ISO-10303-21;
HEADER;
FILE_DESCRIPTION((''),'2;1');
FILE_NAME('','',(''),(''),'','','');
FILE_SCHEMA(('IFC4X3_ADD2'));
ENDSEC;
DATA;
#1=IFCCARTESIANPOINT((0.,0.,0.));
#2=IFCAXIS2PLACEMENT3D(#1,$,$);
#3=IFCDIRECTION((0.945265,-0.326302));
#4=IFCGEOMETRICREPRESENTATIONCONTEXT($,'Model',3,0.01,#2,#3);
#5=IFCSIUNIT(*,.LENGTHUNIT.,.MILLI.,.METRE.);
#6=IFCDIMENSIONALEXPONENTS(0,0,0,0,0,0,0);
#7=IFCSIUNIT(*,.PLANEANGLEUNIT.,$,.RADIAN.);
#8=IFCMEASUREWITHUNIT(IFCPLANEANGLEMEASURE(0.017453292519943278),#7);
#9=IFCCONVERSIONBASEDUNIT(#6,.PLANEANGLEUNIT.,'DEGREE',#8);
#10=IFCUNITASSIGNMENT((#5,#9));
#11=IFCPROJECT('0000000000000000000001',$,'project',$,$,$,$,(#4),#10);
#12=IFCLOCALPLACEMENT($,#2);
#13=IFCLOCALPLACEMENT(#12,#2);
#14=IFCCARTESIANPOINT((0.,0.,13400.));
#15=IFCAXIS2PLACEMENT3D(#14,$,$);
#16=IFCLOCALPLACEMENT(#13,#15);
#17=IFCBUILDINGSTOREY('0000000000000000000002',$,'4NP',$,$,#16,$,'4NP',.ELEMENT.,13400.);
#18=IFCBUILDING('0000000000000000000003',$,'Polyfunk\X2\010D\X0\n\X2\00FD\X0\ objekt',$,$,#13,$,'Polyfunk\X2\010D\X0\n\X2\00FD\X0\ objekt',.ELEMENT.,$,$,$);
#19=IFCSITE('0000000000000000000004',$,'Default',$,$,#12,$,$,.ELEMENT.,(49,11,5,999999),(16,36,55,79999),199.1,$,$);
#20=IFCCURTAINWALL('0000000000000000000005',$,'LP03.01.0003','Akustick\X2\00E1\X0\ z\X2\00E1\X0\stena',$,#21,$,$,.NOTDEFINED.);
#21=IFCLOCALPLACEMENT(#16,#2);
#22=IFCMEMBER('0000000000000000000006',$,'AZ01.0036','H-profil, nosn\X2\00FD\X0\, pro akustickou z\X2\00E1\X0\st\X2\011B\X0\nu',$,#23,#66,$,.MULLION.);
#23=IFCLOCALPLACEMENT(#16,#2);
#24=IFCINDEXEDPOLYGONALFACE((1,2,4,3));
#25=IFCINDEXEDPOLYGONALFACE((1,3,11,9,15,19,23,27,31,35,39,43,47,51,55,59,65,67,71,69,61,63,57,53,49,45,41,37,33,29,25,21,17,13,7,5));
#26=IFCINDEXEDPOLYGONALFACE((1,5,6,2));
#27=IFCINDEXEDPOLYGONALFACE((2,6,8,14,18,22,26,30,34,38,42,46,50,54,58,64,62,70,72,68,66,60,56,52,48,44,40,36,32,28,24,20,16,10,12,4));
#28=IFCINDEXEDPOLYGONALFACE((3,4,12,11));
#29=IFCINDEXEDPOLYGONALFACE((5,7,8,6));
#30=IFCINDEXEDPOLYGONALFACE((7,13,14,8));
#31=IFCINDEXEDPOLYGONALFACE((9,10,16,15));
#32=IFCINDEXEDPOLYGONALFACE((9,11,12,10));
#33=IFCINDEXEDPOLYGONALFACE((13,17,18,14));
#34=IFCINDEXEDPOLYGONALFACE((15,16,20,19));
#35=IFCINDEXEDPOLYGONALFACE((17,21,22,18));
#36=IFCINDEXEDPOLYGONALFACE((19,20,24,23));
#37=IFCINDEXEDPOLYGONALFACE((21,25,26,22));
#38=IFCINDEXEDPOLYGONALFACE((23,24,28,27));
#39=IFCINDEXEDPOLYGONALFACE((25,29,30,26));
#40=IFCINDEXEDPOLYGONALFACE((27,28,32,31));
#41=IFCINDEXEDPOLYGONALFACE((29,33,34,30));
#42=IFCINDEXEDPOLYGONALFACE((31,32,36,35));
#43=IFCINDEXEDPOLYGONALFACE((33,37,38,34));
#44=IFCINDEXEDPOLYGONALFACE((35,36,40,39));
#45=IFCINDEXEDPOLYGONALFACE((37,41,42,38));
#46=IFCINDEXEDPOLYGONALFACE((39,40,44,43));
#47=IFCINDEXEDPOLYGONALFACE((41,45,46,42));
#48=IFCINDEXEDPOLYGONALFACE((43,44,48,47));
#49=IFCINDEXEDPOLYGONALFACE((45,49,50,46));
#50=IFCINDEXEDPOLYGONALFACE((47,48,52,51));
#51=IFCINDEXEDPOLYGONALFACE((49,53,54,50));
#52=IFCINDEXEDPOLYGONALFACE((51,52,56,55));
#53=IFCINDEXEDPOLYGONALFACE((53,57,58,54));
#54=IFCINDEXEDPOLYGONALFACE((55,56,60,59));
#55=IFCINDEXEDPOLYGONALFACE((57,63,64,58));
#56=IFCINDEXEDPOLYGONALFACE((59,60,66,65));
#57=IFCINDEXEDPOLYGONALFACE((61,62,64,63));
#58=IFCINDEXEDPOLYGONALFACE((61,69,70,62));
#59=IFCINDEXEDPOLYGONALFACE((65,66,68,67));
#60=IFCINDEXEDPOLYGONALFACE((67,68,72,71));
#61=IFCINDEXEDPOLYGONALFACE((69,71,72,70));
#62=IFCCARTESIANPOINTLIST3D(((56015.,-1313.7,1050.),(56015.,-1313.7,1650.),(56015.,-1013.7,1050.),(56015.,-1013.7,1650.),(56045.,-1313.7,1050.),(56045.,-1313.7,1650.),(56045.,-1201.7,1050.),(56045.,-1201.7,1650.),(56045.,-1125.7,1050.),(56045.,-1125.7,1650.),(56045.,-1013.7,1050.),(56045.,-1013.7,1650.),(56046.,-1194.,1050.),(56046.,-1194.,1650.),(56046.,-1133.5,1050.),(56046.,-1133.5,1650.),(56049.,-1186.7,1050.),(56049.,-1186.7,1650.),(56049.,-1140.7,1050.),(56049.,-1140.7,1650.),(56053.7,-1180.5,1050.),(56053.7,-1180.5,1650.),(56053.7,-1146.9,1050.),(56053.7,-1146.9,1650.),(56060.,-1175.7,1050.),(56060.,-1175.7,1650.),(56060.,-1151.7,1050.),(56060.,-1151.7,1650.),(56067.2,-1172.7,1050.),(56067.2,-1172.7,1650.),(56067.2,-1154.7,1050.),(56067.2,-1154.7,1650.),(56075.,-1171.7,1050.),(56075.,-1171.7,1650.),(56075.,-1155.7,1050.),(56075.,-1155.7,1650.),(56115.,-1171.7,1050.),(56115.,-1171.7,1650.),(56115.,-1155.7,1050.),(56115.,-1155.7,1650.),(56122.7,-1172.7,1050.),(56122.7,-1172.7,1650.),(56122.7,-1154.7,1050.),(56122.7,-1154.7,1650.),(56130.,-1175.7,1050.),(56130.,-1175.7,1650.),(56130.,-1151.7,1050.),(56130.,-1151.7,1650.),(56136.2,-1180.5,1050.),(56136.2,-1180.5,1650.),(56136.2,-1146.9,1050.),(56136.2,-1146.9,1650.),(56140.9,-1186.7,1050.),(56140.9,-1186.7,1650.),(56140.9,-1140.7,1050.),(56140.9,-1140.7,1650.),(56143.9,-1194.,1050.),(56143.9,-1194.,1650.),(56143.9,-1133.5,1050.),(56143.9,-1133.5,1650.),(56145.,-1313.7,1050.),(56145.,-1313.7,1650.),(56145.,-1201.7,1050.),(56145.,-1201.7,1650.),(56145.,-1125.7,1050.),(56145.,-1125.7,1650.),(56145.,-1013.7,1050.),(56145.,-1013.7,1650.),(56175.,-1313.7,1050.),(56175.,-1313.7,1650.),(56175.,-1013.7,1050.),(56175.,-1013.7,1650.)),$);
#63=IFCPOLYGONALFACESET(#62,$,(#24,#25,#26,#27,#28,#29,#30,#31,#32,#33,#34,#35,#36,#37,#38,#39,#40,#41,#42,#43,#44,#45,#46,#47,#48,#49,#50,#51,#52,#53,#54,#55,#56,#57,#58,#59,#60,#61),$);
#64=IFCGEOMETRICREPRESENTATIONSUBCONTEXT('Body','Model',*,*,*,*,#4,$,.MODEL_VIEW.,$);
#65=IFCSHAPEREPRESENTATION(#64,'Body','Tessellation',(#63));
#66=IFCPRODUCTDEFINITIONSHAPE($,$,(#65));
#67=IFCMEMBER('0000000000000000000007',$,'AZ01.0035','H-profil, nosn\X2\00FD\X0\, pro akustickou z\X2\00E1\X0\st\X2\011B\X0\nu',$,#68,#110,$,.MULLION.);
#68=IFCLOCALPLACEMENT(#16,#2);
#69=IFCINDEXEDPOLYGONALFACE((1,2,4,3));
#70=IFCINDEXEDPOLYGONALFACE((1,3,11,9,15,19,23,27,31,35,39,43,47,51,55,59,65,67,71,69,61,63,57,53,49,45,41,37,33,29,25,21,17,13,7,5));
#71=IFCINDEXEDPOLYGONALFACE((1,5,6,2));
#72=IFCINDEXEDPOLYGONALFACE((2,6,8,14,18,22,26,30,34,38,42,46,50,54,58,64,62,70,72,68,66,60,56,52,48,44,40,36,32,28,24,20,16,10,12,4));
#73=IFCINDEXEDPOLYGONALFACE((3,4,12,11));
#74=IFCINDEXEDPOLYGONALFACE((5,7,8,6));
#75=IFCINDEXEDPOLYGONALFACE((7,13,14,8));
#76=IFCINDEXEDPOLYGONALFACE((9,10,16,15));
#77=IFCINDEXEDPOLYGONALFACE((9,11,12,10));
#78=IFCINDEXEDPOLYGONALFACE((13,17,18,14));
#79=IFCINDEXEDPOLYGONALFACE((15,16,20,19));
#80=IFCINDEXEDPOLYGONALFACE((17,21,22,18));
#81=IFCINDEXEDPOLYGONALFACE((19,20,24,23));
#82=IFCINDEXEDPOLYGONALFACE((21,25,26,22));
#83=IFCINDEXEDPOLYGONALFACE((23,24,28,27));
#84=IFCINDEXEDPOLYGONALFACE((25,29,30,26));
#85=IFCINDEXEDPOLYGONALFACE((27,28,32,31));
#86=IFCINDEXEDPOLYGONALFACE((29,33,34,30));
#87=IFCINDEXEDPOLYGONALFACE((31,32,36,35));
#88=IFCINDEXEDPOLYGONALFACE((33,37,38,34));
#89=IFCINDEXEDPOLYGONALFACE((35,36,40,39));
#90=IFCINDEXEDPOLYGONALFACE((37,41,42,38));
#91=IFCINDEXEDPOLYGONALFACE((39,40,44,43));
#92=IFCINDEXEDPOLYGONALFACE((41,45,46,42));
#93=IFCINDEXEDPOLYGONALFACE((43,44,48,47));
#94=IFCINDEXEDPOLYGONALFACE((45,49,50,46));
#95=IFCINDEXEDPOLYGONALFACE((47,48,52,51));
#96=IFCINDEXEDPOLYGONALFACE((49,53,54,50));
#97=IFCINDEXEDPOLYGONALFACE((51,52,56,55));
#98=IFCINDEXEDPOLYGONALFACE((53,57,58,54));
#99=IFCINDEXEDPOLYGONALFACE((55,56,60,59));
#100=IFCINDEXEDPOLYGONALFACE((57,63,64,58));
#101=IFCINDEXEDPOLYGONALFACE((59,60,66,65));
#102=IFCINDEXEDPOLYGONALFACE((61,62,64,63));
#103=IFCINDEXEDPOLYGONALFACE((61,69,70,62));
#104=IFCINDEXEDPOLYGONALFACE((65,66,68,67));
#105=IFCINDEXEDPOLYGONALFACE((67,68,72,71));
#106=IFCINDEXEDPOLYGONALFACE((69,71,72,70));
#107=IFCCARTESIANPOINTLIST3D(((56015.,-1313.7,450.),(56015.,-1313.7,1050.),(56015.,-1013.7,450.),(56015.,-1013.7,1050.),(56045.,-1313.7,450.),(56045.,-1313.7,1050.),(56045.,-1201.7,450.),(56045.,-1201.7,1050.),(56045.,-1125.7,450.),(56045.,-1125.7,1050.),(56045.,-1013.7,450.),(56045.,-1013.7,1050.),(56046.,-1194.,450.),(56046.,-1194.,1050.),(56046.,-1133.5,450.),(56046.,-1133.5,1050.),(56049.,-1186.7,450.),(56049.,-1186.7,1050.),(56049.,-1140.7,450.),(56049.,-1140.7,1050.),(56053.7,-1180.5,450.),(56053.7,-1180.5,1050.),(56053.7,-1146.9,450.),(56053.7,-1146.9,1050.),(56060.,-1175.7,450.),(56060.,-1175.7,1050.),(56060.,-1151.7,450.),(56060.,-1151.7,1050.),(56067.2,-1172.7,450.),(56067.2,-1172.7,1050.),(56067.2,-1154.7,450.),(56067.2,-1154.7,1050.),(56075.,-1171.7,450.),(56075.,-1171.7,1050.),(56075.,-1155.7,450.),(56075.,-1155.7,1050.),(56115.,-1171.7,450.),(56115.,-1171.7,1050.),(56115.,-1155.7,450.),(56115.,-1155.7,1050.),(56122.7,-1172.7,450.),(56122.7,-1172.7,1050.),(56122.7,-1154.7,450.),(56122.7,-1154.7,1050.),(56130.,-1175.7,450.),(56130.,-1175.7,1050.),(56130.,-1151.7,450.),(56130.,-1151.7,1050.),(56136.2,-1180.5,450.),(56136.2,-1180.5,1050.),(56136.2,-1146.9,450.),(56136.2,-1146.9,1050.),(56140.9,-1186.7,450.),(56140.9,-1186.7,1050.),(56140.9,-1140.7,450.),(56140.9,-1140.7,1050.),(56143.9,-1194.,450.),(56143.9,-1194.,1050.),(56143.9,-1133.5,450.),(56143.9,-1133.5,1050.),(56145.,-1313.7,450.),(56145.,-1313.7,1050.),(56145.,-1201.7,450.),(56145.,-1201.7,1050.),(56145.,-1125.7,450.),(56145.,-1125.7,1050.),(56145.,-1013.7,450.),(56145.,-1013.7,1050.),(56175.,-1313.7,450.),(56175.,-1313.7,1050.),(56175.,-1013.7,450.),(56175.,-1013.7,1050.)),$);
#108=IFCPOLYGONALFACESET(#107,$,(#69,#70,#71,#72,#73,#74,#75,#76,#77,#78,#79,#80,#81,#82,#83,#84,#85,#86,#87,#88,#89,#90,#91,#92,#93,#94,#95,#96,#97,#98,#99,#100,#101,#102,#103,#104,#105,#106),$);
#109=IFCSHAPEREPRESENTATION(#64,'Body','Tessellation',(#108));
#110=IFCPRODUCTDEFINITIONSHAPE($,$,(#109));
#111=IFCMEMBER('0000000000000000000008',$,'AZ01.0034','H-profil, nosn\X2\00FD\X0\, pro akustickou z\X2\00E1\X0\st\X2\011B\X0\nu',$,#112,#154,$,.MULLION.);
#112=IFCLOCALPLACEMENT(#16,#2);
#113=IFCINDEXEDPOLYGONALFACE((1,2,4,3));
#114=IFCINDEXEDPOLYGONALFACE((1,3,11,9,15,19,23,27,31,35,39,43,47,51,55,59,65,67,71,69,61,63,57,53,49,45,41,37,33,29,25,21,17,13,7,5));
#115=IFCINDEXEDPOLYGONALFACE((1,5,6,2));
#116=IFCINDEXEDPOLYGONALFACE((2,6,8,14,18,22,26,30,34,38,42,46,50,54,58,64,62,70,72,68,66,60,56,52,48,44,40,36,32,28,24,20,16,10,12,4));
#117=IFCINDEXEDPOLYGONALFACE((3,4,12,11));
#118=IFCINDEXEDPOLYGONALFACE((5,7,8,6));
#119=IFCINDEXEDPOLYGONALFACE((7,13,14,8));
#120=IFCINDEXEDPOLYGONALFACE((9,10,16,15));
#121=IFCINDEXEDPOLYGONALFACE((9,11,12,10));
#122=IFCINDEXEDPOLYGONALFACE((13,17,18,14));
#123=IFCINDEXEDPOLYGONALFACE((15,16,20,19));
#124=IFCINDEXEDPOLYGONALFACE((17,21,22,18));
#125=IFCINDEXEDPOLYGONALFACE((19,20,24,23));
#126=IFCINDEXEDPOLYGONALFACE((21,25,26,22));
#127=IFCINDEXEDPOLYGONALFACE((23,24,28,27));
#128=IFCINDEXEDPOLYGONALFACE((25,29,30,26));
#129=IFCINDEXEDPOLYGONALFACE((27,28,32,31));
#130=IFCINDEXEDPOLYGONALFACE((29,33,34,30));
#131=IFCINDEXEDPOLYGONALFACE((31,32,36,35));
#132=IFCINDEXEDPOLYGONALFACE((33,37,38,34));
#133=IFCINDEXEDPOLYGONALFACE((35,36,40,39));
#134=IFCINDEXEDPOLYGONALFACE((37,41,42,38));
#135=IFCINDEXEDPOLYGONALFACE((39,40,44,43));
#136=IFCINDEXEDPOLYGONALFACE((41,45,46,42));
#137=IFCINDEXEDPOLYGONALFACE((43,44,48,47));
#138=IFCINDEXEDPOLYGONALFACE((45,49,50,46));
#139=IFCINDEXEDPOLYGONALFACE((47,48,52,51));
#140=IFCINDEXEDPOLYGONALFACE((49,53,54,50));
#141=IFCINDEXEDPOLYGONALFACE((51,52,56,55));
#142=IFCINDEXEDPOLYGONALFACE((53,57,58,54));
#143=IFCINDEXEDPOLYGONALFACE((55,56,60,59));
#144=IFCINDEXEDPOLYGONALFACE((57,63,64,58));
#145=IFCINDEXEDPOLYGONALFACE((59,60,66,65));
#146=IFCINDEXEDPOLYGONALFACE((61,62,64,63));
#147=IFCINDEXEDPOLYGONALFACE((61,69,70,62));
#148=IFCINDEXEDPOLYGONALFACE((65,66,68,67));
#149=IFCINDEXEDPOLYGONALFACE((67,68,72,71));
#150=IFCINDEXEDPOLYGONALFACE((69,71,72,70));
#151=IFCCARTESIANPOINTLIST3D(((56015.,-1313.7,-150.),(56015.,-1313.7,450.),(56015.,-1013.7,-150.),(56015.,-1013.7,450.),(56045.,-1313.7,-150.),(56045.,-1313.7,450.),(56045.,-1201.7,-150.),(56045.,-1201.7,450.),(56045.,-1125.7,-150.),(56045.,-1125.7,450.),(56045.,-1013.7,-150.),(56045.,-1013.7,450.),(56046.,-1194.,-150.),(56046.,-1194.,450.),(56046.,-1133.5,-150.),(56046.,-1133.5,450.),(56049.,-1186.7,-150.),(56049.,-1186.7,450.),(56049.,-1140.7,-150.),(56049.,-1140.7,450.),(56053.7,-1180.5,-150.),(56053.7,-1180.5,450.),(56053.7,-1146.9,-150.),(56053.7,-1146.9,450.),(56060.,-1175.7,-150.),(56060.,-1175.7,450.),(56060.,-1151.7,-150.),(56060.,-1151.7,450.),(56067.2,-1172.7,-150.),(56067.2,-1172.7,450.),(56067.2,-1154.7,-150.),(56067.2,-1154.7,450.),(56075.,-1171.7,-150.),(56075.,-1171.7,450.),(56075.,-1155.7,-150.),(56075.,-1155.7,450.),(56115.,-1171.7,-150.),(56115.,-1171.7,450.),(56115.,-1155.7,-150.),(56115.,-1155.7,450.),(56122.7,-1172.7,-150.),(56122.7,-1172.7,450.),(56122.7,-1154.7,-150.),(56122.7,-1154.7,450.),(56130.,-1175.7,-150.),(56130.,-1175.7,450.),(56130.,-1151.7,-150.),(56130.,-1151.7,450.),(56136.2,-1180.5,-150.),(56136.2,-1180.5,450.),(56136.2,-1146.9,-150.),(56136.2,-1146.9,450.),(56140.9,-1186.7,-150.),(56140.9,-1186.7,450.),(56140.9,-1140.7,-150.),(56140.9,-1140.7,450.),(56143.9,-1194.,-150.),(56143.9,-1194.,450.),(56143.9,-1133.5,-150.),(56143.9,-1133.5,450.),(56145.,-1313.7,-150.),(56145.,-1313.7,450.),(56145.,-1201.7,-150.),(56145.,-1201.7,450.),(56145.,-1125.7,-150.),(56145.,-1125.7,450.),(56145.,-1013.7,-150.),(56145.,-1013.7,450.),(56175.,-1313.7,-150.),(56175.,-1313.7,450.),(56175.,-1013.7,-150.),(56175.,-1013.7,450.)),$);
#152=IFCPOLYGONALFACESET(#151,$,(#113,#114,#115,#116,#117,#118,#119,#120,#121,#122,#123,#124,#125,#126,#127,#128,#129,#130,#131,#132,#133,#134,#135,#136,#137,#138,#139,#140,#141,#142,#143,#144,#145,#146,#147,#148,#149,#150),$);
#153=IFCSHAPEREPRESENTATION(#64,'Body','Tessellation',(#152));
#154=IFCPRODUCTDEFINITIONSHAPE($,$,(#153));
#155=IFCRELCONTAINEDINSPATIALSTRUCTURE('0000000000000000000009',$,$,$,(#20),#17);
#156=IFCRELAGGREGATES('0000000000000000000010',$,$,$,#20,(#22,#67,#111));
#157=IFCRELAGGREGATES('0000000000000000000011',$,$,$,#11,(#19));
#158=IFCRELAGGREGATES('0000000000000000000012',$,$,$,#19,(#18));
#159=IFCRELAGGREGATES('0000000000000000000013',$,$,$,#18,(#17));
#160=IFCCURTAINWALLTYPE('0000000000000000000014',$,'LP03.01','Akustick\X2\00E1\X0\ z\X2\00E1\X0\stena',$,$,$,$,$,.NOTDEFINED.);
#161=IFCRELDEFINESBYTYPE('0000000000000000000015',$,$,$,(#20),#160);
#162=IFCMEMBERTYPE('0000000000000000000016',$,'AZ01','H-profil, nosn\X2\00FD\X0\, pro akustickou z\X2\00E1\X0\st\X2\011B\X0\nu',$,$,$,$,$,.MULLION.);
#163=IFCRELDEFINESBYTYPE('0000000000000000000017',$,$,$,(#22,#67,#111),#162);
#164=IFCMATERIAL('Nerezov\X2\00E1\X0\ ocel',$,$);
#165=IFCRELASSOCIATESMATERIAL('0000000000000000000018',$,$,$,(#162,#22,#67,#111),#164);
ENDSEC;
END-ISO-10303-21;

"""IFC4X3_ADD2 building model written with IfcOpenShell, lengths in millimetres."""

from ifc_helpers import new_model, entity, si_unit, converted_unit, direction, frame, frame_2d, origin, place, context, subcontext, project, spatial, polyline, circle_curve, parameter, trimmed, segment, composite_curve, outline, extrude, source, transform, mapped, material, material_profile, profile_set, profile_usage, type_object, element, aggregate, save


model = new_model("IFC4X3_ADD2")

# Units and contexts
model_context = context("Model", 3, precision=0.01, world=origin(), true_north=direction((0.945265, -0.326302)))
body_context = subcontext(model_context, "Body", "Model", "MODEL_VIEW")
ifc_project = project(units=[si_unit("LENGTHUNIT", "METRE", prefix="MILLI"), converted_unit("PLANEANGLEUNIT", "DEGREE", entity("IfcPlaneAngleMeasure", 0.017453292519943278), si_unit("PLANEANGLEUNIT", "RADIAN"), dimensions=[0, 0, 0, 0, 0, 0, 0])], contexts=[model_context])

# Site, building, storey
site_placement = place(None, origin())
site = spatial("IfcSite", under=ifc_project, at=site_placement, Name="Default", CompositionType="ELEMENT", RefLatitude=(49, 11, 5, 999999), RefLongitude=(16, 36, 55, 79999), RefElevation=199.1)
building_placement = place(site_placement, origin())
building = spatial("IfcBuilding", under=site, at=building_placement, Name="Polyfunkčný objekt", LongName="Polyfunkčný objekt", CompositionType="ELEMENT")
storey_placement = place(building_placement, frame((0.0, 0.0, 13400.0)))
storey = spatial("IfcBuildingStorey", under=building, at=storey_placement, Name="4NP", LongName="4NP", CompositionType="ELEMENT", Elevation=13400.0)

# Curtain wall, members
curtain_wall_type = type_object("IfcCurtainWallType", Name="LP03.01", Description="Akustická zástena", PredefinedType="NOTDEFINED")
curtain_wall_placement = place(storey_placement, frame((0.0, 0.0, -13400.0)))
curtain_wall = element("IfcCurtainWall", 1, at=curtain_wall_placement, inside=storey, type_object=curtain_wall_type, Name="LP03.01.0003", Description="Akustická zástena", PredefinedType="NOTDEFINED")
ifc_material_1 = material(Name="Nerezová ocel")
ifc_material_profile = material_profile(ifc_material_1, outline(composite_curve([segment(polyline([(50.0, -150.0), (80.0, -150.0)]), True, "CONTINUOUS"), segment(polyline([(80.0, -150.0), (80.0, 150.0)]), True, "CONTINUOUS"), segment(polyline([(80.0, 150.0), (50.0, 150.0)]), True, "CONTINUOUS"), segment(polyline([(50.0, 150.0), (50.0, 38.0)]), True, "CONTINUOUS"), segment(trimmed(circle_curve(frame_2d((20.0, 38.0), x_axis=(0.0, 1.0)), 30.0), [parameter(180.0)], [parameter(270.0)], True, "PARAMETER"), False, "CONTINUOUS"), segment(polyline([(20.0, 8.0), (-20.0, 8.0)]), True, "CONTINUOUS"), segment(trimmed(circle_curve(frame_2d((-20.0, 38.0), x_axis=(0.0, 1.0)), 30.0), [parameter(90.0)], [parameter(180.0)], True, "PARAMETER"), False, "CONTINUOUS"), segment(polyline([(-50.0, 38.0), (-50.0, 150.0)]), True, "CONTINUOUS"), segment(polyline([(-50.0, 150.0), (-80.0, 150.0)]), True, "CONTINUOUS"), segment(polyline([(-80.0, 150.0), (-80.0, -150.0)]), True, "CONTINUOUS"), segment(polyline([(-80.0, -150.0), (-50.0, -150.0)]), True, "CONTINUOUS"), segment(polyline([(-50.0, -150.0), (-50.0, -38.0)]), True, "CONTINUOUS"), segment(trimmed(circle_curve(frame_2d((-20.0, -38.0), x_axis=(0.0, 1.0)), 30.0), [parameter(0.0)], [parameter(90.0)], True, "PARAMETER"), False, "CONTINUOUS"), segment(polyline([(-20.0, -8.0), (20.0, -8.0)]), True, "CONTINUOUS"), segment(trimmed(circle_curve(frame_2d((20.0, -38.0), x_axis=(0.0, 1.0)), 30.0), [parameter(270.0)], [parameter(0.0)], True, "PARAMETER"), False, "CONTINUOUS"), segment(polyline([(50.0, -38.0), (50.0, -150.0)]), True, "CONTINUOUS")], self_intersect=False)), Name="Profil zástena")
ifc_profile_set = profile_set([ifc_material_profile], Name="Profil zástena")
ifc_profile_usage = profile_usage(ifc_profile_set)
member_type = type_object("IfcMemberType", Name="AZ01", Description="H-profil, nosný, pro akustickou zástěnu", PredefinedType="MULLION", material=ifc_profile_set)
shared_shape_1 = source(origin(), body_context, "Body", "SweptSolid", [
    extrude(outline(composite_curve([segment(polyline([(50.0, -150.0), (80.0, -150.0)]), True, "CONTINUOUS"), segment(polyline([(80.0, -150.0), (80.0, 150.0)]), True, "CONTINUOUS"), segment(polyline([(80.0, 150.0), (50.0, 150.0)]), True, "CONTINUOUS"), segment(polyline([(50.0, 150.0), (50.0, 38.0)]), True, "CONTINUOUS"), segment(trimmed(circle_curve(frame_2d((20.0, 38.0), x_axis=(0.0, 1.0)), 30.0), [parameter(180.0)], [parameter(270.0)], True, "PARAMETER"), False, "CONTINUOUS"), segment(polyline([(20.0, 8.0), (-20.0, 8.0)]), True, "CONTINUOUS"), segment(trimmed(circle_curve(frame_2d((-20.0, 38.0), x_axis=(0.0, 1.0)), 30.0), [parameter(90.0)], [parameter(180.0)], True, "PARAMETER"), False, "CONTINUOUS"), segment(polyline([(-50.0, 38.0), (-50.0, 150.0)]), True, "CONTINUOUS"), segment(polyline([(-50.0, 150.0), (-80.0, 150.0)]), True, "CONTINUOUS"), segment(polyline([(-80.0, 150.0), (-80.0, -150.0)]), True, "CONTINUOUS"), segment(polyline([(-80.0, -150.0), (-50.0, -150.0)]), True, "CONTINUOUS"), segment(polyline([(-50.0, -150.0), (-50.0, -38.0)]), True, "CONTINUOUS"), segment(trimmed(circle_curve(frame_2d((-20.0, -38.0), x_axis=(0.0, 1.0)), 30.0), [parameter(0.0)], [parameter(90.0)], True, "PARAMETER"), False, "CONTINUOUS"), segment(polyline([(-20.0, -8.0), (20.0, -8.0)]), True, "CONTINUOUS"), segment(trimmed(circle_curve(frame_2d((20.0, -38.0), x_axis=(0.0, 1.0)), 30.0), [parameter(270.0)], [parameter(0.0)], True, "PARAMETER"), False, "CONTINUOUS"), segment(polyline([(50.0, -38.0), (50.0, -150.0)]), True, "CONTINUOUS")], self_intersect=False)), frame((-150.0, 0.0, -600.0), z_axis=(0.0, 0.0, 1.0), x_axis=(0.0, 1.0, 0.0)), (0.0, 0.0, 1.0), 600.0),
])
member_1_placement = place(curtain_wall_placement, frame((56095.0, -1313.7, 15050.0), z_axis=(0.0, 0.0, 1.0), x_axis=(0.0, -1.0, 0.0)))
member_1 = element("IfcMember", 2, at=member_1_placement, type_object=member_type, material=ifc_profile_usage, Name="AZ01.0036", Description="H-profil, nosný, pro akustickou zástěnu", PredefinedType="MULLION", context=body_context, shape_type="MappedRepresentation", body=[
    mapped(shared_shape_1, transform((0.0, 0.0, 0.0), scale=1.0)),
])
member_2_placement = place(curtain_wall_placement, frame((56095.0, -1313.7, 14450.0), z_axis=(0.0, 0.0, 1.0), x_axis=(0.0, -1.0, 0.0)))
member_2 = element("IfcMember", 3, at=member_2_placement, type_object=member_type, material=ifc_profile_usage, Name="AZ01.0035", Description="H-profil, nosný, pro akustickou zástěnu", PredefinedType="MULLION", context=body_context, shape_type="MappedRepresentation", body=[
    mapped(shared_shape_1, transform((0.0, 0.0, 0.0), scale=1.0)),
])
shared_shape_2 = source(origin(), body_context, "Body", "SweptSolid", [
    extrude(outline(composite_curve([segment(polyline([(50.0, -150.0), (80.0, -150.0)]), True, "CONTINUOUS"), segment(polyline([(80.0, -150.0), (80.0, 150.0)]), True, "CONTINUOUS"), segment(polyline([(80.0, 150.0), (50.0, 150.0)]), True, "CONTINUOUS"), segment(polyline([(50.0, 150.0), (50.0, 38.0)]), True, "CONTINUOUS"), segment(trimmed(circle_curve(frame_2d((20.0, 38.0), x_axis=(0.0, 1.0)), 30.0), [parameter(180.0)], [parameter(270.0)], True, "PARAMETER"), False, "CONTINUOUS"), segment(polyline([(20.0, 8.0), (-20.0, 8.0)]), True, "CONTINUOUS"), segment(trimmed(circle_curve(frame_2d((-20.0, 38.0), x_axis=(0.0, 1.0)), 30.0), [parameter(90.0)], [parameter(180.0)], True, "PARAMETER"), False, "CONTINUOUS"), segment(polyline([(-50.0, 38.0), (-50.0, 150.0)]), True, "CONTINUOUS"), segment(polyline([(-50.0, 150.0), (-80.0, 150.0)]), True, "CONTINUOUS"), segment(polyline([(-80.0, 150.0), (-80.0, -150.0)]), True, "CONTINUOUS"), segment(polyline([(-80.0, -150.0), (-50.0, -150.0)]), True, "CONTINUOUS"), segment(polyline([(-50.0, -150.0), (-50.0, -38.0)]), True, "CONTINUOUS"), segment(trimmed(circle_curve(frame_2d((-20.0, -38.0), x_axis=(0.0, 1.0)), 30.0), [parameter(0.0)], [parameter(90.0)], True, "PARAMETER"), False, "CONTINUOUS"), segment(polyline([(-20.0, -8.0), (20.0, -8.0)]), True, "CONTINUOUS"), segment(trimmed(circle_curve(frame_2d((20.0, -38.0), x_axis=(0.0, 1.0)), 30.0), [parameter(270.0)], [parameter(0.0)], True, "PARAMETER"), False, "CONTINUOUS"), segment(polyline([(50.0, -38.0), (50.0, -150.0)]), True, "CONTINUOUS")], self_intersect=False)), frame((-150.0, 0.0, -600.0), z_axis=(0.0, 0.0, 1.0), x_axis=(0.0, 1.0, 0.0)), (0.0, 0.0, 1.0), 600.0),
])
member_3_placement = place(curtain_wall_placement, frame((56095.0, -1313.7, 13850.0), z_axis=(0.0, 0.0, 1.0), x_axis=(0.0, -1.0, 0.0)))
member_3 = element("IfcMember", 4, at=member_3_placement, type_object=member_type, material=ifc_profile_usage, Name="AZ01.0034", Description="H-profil, nosný, pro akustickou zástěnu", PredefinedType="MULLION", context=body_context, shape_type="MappedRepresentation", body=[
    mapped(shared_shape_2, transform((0.0, 0.0, 0.0), scale=1.0)),
])
aggregate(curtain_wall, [member_1, member_2, member_3])

save(model, "model.ifc")
